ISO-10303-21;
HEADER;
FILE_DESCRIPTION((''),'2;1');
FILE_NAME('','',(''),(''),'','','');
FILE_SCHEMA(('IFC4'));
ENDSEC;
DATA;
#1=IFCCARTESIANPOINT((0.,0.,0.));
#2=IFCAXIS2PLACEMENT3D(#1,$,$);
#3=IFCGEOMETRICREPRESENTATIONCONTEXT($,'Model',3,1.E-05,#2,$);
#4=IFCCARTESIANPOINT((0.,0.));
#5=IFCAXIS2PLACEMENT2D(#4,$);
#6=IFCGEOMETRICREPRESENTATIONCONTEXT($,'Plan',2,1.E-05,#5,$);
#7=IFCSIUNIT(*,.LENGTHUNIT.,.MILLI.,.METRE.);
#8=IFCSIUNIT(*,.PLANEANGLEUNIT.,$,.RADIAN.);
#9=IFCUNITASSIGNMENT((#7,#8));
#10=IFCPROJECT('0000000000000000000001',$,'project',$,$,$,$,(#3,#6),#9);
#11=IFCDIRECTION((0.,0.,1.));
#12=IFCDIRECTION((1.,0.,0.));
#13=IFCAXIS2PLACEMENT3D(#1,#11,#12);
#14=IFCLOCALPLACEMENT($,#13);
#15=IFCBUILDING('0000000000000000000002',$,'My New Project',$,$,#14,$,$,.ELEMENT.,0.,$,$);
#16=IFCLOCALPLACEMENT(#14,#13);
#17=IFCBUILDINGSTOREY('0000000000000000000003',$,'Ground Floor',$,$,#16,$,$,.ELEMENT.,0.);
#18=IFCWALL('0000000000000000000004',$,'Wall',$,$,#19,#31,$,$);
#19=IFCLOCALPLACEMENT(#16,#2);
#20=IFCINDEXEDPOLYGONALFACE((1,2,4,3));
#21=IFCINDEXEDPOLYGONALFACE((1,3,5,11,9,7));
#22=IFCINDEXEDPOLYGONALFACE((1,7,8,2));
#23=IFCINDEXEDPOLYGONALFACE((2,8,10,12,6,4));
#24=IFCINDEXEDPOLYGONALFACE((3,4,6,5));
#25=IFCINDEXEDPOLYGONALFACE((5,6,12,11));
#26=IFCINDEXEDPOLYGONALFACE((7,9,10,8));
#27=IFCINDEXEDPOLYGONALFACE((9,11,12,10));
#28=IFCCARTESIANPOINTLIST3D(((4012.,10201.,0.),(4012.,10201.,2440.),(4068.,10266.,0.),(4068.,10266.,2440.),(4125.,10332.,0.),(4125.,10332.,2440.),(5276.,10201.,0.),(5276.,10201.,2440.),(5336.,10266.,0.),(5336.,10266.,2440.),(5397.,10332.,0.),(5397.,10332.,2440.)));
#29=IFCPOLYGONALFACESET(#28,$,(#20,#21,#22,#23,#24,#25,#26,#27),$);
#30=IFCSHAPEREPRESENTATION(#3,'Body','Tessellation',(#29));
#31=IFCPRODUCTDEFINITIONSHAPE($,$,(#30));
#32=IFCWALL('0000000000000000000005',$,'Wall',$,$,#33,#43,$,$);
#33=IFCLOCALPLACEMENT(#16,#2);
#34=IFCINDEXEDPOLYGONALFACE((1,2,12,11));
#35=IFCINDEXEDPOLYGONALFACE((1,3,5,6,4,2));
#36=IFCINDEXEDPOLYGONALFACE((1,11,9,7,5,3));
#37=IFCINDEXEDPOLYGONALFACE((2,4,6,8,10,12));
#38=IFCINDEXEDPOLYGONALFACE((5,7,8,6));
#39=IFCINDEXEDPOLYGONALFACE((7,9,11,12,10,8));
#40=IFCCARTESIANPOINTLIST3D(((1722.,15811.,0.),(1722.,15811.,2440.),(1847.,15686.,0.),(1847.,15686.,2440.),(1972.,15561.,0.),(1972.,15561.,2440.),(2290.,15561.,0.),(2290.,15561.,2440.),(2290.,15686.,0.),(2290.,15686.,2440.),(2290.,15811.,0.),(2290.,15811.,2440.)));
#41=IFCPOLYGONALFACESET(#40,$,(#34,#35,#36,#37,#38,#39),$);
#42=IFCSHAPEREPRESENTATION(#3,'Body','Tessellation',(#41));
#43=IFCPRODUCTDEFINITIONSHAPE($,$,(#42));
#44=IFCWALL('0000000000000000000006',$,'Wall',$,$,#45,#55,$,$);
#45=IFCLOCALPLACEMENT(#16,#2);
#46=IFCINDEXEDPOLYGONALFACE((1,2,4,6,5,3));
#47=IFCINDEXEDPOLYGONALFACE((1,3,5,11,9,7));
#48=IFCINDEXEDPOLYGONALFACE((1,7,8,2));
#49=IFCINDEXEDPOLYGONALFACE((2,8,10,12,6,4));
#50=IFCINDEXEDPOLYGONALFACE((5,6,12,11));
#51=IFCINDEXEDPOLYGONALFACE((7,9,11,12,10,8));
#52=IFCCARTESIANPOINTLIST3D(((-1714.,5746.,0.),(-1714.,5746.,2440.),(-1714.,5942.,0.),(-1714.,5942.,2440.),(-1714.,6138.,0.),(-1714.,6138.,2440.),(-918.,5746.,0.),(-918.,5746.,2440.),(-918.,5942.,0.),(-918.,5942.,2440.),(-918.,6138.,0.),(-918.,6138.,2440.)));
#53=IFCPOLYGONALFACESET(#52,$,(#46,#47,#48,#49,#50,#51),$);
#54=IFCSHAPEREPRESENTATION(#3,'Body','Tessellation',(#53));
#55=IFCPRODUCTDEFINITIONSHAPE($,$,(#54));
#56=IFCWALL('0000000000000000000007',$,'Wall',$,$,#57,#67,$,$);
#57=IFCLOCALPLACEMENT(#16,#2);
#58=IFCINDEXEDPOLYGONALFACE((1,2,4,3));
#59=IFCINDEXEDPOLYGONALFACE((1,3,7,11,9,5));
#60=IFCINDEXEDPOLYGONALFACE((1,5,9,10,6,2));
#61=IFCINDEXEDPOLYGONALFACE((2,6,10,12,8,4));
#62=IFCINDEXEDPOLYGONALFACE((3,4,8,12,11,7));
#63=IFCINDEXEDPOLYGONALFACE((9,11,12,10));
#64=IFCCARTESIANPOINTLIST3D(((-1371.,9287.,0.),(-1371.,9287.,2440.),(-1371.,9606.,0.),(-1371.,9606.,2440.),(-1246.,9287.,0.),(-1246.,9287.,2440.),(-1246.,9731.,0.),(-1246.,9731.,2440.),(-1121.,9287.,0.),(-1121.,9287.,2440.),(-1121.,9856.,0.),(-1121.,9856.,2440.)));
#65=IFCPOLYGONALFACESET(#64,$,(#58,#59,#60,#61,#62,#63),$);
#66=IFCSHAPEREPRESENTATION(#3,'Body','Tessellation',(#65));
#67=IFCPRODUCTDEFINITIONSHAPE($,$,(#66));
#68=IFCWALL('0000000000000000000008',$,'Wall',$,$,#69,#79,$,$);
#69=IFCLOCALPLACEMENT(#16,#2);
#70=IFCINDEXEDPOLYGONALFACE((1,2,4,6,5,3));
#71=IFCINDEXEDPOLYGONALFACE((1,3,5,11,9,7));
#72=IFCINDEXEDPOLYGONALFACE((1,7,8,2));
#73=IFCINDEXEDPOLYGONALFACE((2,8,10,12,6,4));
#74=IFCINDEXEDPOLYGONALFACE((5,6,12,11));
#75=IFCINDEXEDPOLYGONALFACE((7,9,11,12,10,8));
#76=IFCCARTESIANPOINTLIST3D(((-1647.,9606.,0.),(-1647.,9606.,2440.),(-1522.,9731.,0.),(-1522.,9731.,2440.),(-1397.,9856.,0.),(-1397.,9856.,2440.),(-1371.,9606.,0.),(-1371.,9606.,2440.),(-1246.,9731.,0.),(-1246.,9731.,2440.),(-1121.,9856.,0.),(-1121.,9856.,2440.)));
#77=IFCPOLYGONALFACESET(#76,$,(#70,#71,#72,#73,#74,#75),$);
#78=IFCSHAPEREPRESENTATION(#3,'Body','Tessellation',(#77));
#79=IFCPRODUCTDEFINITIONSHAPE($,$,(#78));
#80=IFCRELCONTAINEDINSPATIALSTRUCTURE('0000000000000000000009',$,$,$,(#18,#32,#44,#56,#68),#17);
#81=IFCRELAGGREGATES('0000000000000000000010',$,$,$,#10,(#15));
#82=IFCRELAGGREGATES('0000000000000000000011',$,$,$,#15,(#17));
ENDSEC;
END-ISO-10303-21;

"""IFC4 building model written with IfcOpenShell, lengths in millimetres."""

from ifc_helpers import new_model, si_unit, origin, origin_with_axes, origin_2d, place, context, project, spatial, polyline, outline, extrude, element, save


model = new_model("IFC4")

# Units and contexts
model_context = context("Model", 3, precision=1e-05, world=origin())
plan_context = context("Plan", 2, precision=1e-05, world=origin_2d())
ifc_project = project(units=[si_unit("LENGTHUNIT", "METRE", prefix="MILLI"), si_unit("PLANEANGLEUNIT", "RADIAN")], contexts=[model_context, plan_context])

# Building, storey
building_placement = place(None, origin_with_axes())
building = spatial("IfcBuilding", under=ifc_project, at=building_placement, Name="My New Project", CompositionType="ELEMENT", ElevationOfRefHeight=0.0)
storey_placement = place(building_placement, origin_with_axes())
storey = spatial("IfcBuildingStorey", under=building, at=storey_placement, Name="Ground Floor", CompositionType="ELEMENT", Elevation=0.0)

# Walls
wall_1_placement = place(storey_placement, origin_with_axes())
element("IfcWall", 1, at=wall_1_placement, inside=storey, Name="Wall", context=model_context, shape_type="SweptSolid", body=[
    extrude(outline(polyline([(5336.0, 10266.0, 0.0), (5276.0, 10201.0, 0.0), (4012.0, 10201.0, 0.0), (4068.0, 10266.0, 0.0), (4125.0, 10332.0, 0.0), (5397.0, 10332.0, 0.0), (5336.0, 10266.0, 0.0)])), origin_with_axes(), (0.0, 0.0, 1.0), 2440.0),
])
wall_2_placement = place(storey_placement, origin_with_axes())
element("IfcWall", 2, at=wall_2_placement, inside=storey, Name="Wall", context=model_context, shape_type="SweptSolid", body=[
    extrude(outline(polyline([(2290.0, 15686.0, 0.0), (2290.0, 15561.0, 0.0), (1972.0, 15561.0, 0.0), (1847.0, 15686.0, 0.0), (1722.0, 15811.0, 0.0), (2290.0, 15811.0, 0.0), (2290.0, 15686.0, 0.0)])), origin_with_axes(), (0.0, 0.0, 1.0), 2440.0),
])
wall_3_placement = place(storey_placement, origin_with_axes())
element("IfcWall", 3, at=wall_3_placement, inside=storey, Name="Wall", context=model_context, shape_type="SweptSolid", body=[
    extrude(outline(polyline([(-1714.0, 5942.0, 0.0), (-1714.0, 6138.0, 0.0), (-918.0, 6138.0, 0.0), (-918.0, 5942.0, 0.0), (-918.0, 5746.0, 0.0), (-1714.0, 5746.0, 0.0), (-1714.0, 5942.0, 0.0)])), origin_with_axes(), (0.0, 0.0, 1.0), 2440.0),
])
wall_4_placement = place(storey_placement, origin_with_axes())
element("IfcWall", 4, at=wall_4_placement, inside=storey, Name="Wall", context=model_context, shape_type="SweptSolid", body=[
    extrude(outline(polyline([(-1246.0, 9287.0, 0.0), (-1371.0, 9287.0, 0.0), (-1371.0, 9606.0, 0.0), (-1246.0, 9731.0, 0.0), (-1121.0, 9856.0, 0.0), (-1121.0, 9287.0, 0.0), (-1246.0, 9287.0, 0.0)])), origin_with_axes(), (0.0, 0.0, 1.0), 2440.0),
])
wall_5_placement = place(storey_placement, origin_with_axes())
element("IfcWall", 5, at=wall_5_placement, inside=storey, Name="Wall", context=model_context, shape_type="SweptSolid", body=[
    extrude(outline(polyline([(-1522.0, 9731.0, 0.0), (-1397.0, 9856.0, 0.0), (-1121.0, 9856.0, 0.0), (-1246.0, 9731.0, 0.0), (-1371.0, 9606.0, 0.0), (-1647.0, 9606.0, 0.0), (-1522.0, 9731.0, 0.0)])), origin_with_axes(), (0.0, 0.0, 1.0), 2440.0),
])

save(model, "model.ifc")
